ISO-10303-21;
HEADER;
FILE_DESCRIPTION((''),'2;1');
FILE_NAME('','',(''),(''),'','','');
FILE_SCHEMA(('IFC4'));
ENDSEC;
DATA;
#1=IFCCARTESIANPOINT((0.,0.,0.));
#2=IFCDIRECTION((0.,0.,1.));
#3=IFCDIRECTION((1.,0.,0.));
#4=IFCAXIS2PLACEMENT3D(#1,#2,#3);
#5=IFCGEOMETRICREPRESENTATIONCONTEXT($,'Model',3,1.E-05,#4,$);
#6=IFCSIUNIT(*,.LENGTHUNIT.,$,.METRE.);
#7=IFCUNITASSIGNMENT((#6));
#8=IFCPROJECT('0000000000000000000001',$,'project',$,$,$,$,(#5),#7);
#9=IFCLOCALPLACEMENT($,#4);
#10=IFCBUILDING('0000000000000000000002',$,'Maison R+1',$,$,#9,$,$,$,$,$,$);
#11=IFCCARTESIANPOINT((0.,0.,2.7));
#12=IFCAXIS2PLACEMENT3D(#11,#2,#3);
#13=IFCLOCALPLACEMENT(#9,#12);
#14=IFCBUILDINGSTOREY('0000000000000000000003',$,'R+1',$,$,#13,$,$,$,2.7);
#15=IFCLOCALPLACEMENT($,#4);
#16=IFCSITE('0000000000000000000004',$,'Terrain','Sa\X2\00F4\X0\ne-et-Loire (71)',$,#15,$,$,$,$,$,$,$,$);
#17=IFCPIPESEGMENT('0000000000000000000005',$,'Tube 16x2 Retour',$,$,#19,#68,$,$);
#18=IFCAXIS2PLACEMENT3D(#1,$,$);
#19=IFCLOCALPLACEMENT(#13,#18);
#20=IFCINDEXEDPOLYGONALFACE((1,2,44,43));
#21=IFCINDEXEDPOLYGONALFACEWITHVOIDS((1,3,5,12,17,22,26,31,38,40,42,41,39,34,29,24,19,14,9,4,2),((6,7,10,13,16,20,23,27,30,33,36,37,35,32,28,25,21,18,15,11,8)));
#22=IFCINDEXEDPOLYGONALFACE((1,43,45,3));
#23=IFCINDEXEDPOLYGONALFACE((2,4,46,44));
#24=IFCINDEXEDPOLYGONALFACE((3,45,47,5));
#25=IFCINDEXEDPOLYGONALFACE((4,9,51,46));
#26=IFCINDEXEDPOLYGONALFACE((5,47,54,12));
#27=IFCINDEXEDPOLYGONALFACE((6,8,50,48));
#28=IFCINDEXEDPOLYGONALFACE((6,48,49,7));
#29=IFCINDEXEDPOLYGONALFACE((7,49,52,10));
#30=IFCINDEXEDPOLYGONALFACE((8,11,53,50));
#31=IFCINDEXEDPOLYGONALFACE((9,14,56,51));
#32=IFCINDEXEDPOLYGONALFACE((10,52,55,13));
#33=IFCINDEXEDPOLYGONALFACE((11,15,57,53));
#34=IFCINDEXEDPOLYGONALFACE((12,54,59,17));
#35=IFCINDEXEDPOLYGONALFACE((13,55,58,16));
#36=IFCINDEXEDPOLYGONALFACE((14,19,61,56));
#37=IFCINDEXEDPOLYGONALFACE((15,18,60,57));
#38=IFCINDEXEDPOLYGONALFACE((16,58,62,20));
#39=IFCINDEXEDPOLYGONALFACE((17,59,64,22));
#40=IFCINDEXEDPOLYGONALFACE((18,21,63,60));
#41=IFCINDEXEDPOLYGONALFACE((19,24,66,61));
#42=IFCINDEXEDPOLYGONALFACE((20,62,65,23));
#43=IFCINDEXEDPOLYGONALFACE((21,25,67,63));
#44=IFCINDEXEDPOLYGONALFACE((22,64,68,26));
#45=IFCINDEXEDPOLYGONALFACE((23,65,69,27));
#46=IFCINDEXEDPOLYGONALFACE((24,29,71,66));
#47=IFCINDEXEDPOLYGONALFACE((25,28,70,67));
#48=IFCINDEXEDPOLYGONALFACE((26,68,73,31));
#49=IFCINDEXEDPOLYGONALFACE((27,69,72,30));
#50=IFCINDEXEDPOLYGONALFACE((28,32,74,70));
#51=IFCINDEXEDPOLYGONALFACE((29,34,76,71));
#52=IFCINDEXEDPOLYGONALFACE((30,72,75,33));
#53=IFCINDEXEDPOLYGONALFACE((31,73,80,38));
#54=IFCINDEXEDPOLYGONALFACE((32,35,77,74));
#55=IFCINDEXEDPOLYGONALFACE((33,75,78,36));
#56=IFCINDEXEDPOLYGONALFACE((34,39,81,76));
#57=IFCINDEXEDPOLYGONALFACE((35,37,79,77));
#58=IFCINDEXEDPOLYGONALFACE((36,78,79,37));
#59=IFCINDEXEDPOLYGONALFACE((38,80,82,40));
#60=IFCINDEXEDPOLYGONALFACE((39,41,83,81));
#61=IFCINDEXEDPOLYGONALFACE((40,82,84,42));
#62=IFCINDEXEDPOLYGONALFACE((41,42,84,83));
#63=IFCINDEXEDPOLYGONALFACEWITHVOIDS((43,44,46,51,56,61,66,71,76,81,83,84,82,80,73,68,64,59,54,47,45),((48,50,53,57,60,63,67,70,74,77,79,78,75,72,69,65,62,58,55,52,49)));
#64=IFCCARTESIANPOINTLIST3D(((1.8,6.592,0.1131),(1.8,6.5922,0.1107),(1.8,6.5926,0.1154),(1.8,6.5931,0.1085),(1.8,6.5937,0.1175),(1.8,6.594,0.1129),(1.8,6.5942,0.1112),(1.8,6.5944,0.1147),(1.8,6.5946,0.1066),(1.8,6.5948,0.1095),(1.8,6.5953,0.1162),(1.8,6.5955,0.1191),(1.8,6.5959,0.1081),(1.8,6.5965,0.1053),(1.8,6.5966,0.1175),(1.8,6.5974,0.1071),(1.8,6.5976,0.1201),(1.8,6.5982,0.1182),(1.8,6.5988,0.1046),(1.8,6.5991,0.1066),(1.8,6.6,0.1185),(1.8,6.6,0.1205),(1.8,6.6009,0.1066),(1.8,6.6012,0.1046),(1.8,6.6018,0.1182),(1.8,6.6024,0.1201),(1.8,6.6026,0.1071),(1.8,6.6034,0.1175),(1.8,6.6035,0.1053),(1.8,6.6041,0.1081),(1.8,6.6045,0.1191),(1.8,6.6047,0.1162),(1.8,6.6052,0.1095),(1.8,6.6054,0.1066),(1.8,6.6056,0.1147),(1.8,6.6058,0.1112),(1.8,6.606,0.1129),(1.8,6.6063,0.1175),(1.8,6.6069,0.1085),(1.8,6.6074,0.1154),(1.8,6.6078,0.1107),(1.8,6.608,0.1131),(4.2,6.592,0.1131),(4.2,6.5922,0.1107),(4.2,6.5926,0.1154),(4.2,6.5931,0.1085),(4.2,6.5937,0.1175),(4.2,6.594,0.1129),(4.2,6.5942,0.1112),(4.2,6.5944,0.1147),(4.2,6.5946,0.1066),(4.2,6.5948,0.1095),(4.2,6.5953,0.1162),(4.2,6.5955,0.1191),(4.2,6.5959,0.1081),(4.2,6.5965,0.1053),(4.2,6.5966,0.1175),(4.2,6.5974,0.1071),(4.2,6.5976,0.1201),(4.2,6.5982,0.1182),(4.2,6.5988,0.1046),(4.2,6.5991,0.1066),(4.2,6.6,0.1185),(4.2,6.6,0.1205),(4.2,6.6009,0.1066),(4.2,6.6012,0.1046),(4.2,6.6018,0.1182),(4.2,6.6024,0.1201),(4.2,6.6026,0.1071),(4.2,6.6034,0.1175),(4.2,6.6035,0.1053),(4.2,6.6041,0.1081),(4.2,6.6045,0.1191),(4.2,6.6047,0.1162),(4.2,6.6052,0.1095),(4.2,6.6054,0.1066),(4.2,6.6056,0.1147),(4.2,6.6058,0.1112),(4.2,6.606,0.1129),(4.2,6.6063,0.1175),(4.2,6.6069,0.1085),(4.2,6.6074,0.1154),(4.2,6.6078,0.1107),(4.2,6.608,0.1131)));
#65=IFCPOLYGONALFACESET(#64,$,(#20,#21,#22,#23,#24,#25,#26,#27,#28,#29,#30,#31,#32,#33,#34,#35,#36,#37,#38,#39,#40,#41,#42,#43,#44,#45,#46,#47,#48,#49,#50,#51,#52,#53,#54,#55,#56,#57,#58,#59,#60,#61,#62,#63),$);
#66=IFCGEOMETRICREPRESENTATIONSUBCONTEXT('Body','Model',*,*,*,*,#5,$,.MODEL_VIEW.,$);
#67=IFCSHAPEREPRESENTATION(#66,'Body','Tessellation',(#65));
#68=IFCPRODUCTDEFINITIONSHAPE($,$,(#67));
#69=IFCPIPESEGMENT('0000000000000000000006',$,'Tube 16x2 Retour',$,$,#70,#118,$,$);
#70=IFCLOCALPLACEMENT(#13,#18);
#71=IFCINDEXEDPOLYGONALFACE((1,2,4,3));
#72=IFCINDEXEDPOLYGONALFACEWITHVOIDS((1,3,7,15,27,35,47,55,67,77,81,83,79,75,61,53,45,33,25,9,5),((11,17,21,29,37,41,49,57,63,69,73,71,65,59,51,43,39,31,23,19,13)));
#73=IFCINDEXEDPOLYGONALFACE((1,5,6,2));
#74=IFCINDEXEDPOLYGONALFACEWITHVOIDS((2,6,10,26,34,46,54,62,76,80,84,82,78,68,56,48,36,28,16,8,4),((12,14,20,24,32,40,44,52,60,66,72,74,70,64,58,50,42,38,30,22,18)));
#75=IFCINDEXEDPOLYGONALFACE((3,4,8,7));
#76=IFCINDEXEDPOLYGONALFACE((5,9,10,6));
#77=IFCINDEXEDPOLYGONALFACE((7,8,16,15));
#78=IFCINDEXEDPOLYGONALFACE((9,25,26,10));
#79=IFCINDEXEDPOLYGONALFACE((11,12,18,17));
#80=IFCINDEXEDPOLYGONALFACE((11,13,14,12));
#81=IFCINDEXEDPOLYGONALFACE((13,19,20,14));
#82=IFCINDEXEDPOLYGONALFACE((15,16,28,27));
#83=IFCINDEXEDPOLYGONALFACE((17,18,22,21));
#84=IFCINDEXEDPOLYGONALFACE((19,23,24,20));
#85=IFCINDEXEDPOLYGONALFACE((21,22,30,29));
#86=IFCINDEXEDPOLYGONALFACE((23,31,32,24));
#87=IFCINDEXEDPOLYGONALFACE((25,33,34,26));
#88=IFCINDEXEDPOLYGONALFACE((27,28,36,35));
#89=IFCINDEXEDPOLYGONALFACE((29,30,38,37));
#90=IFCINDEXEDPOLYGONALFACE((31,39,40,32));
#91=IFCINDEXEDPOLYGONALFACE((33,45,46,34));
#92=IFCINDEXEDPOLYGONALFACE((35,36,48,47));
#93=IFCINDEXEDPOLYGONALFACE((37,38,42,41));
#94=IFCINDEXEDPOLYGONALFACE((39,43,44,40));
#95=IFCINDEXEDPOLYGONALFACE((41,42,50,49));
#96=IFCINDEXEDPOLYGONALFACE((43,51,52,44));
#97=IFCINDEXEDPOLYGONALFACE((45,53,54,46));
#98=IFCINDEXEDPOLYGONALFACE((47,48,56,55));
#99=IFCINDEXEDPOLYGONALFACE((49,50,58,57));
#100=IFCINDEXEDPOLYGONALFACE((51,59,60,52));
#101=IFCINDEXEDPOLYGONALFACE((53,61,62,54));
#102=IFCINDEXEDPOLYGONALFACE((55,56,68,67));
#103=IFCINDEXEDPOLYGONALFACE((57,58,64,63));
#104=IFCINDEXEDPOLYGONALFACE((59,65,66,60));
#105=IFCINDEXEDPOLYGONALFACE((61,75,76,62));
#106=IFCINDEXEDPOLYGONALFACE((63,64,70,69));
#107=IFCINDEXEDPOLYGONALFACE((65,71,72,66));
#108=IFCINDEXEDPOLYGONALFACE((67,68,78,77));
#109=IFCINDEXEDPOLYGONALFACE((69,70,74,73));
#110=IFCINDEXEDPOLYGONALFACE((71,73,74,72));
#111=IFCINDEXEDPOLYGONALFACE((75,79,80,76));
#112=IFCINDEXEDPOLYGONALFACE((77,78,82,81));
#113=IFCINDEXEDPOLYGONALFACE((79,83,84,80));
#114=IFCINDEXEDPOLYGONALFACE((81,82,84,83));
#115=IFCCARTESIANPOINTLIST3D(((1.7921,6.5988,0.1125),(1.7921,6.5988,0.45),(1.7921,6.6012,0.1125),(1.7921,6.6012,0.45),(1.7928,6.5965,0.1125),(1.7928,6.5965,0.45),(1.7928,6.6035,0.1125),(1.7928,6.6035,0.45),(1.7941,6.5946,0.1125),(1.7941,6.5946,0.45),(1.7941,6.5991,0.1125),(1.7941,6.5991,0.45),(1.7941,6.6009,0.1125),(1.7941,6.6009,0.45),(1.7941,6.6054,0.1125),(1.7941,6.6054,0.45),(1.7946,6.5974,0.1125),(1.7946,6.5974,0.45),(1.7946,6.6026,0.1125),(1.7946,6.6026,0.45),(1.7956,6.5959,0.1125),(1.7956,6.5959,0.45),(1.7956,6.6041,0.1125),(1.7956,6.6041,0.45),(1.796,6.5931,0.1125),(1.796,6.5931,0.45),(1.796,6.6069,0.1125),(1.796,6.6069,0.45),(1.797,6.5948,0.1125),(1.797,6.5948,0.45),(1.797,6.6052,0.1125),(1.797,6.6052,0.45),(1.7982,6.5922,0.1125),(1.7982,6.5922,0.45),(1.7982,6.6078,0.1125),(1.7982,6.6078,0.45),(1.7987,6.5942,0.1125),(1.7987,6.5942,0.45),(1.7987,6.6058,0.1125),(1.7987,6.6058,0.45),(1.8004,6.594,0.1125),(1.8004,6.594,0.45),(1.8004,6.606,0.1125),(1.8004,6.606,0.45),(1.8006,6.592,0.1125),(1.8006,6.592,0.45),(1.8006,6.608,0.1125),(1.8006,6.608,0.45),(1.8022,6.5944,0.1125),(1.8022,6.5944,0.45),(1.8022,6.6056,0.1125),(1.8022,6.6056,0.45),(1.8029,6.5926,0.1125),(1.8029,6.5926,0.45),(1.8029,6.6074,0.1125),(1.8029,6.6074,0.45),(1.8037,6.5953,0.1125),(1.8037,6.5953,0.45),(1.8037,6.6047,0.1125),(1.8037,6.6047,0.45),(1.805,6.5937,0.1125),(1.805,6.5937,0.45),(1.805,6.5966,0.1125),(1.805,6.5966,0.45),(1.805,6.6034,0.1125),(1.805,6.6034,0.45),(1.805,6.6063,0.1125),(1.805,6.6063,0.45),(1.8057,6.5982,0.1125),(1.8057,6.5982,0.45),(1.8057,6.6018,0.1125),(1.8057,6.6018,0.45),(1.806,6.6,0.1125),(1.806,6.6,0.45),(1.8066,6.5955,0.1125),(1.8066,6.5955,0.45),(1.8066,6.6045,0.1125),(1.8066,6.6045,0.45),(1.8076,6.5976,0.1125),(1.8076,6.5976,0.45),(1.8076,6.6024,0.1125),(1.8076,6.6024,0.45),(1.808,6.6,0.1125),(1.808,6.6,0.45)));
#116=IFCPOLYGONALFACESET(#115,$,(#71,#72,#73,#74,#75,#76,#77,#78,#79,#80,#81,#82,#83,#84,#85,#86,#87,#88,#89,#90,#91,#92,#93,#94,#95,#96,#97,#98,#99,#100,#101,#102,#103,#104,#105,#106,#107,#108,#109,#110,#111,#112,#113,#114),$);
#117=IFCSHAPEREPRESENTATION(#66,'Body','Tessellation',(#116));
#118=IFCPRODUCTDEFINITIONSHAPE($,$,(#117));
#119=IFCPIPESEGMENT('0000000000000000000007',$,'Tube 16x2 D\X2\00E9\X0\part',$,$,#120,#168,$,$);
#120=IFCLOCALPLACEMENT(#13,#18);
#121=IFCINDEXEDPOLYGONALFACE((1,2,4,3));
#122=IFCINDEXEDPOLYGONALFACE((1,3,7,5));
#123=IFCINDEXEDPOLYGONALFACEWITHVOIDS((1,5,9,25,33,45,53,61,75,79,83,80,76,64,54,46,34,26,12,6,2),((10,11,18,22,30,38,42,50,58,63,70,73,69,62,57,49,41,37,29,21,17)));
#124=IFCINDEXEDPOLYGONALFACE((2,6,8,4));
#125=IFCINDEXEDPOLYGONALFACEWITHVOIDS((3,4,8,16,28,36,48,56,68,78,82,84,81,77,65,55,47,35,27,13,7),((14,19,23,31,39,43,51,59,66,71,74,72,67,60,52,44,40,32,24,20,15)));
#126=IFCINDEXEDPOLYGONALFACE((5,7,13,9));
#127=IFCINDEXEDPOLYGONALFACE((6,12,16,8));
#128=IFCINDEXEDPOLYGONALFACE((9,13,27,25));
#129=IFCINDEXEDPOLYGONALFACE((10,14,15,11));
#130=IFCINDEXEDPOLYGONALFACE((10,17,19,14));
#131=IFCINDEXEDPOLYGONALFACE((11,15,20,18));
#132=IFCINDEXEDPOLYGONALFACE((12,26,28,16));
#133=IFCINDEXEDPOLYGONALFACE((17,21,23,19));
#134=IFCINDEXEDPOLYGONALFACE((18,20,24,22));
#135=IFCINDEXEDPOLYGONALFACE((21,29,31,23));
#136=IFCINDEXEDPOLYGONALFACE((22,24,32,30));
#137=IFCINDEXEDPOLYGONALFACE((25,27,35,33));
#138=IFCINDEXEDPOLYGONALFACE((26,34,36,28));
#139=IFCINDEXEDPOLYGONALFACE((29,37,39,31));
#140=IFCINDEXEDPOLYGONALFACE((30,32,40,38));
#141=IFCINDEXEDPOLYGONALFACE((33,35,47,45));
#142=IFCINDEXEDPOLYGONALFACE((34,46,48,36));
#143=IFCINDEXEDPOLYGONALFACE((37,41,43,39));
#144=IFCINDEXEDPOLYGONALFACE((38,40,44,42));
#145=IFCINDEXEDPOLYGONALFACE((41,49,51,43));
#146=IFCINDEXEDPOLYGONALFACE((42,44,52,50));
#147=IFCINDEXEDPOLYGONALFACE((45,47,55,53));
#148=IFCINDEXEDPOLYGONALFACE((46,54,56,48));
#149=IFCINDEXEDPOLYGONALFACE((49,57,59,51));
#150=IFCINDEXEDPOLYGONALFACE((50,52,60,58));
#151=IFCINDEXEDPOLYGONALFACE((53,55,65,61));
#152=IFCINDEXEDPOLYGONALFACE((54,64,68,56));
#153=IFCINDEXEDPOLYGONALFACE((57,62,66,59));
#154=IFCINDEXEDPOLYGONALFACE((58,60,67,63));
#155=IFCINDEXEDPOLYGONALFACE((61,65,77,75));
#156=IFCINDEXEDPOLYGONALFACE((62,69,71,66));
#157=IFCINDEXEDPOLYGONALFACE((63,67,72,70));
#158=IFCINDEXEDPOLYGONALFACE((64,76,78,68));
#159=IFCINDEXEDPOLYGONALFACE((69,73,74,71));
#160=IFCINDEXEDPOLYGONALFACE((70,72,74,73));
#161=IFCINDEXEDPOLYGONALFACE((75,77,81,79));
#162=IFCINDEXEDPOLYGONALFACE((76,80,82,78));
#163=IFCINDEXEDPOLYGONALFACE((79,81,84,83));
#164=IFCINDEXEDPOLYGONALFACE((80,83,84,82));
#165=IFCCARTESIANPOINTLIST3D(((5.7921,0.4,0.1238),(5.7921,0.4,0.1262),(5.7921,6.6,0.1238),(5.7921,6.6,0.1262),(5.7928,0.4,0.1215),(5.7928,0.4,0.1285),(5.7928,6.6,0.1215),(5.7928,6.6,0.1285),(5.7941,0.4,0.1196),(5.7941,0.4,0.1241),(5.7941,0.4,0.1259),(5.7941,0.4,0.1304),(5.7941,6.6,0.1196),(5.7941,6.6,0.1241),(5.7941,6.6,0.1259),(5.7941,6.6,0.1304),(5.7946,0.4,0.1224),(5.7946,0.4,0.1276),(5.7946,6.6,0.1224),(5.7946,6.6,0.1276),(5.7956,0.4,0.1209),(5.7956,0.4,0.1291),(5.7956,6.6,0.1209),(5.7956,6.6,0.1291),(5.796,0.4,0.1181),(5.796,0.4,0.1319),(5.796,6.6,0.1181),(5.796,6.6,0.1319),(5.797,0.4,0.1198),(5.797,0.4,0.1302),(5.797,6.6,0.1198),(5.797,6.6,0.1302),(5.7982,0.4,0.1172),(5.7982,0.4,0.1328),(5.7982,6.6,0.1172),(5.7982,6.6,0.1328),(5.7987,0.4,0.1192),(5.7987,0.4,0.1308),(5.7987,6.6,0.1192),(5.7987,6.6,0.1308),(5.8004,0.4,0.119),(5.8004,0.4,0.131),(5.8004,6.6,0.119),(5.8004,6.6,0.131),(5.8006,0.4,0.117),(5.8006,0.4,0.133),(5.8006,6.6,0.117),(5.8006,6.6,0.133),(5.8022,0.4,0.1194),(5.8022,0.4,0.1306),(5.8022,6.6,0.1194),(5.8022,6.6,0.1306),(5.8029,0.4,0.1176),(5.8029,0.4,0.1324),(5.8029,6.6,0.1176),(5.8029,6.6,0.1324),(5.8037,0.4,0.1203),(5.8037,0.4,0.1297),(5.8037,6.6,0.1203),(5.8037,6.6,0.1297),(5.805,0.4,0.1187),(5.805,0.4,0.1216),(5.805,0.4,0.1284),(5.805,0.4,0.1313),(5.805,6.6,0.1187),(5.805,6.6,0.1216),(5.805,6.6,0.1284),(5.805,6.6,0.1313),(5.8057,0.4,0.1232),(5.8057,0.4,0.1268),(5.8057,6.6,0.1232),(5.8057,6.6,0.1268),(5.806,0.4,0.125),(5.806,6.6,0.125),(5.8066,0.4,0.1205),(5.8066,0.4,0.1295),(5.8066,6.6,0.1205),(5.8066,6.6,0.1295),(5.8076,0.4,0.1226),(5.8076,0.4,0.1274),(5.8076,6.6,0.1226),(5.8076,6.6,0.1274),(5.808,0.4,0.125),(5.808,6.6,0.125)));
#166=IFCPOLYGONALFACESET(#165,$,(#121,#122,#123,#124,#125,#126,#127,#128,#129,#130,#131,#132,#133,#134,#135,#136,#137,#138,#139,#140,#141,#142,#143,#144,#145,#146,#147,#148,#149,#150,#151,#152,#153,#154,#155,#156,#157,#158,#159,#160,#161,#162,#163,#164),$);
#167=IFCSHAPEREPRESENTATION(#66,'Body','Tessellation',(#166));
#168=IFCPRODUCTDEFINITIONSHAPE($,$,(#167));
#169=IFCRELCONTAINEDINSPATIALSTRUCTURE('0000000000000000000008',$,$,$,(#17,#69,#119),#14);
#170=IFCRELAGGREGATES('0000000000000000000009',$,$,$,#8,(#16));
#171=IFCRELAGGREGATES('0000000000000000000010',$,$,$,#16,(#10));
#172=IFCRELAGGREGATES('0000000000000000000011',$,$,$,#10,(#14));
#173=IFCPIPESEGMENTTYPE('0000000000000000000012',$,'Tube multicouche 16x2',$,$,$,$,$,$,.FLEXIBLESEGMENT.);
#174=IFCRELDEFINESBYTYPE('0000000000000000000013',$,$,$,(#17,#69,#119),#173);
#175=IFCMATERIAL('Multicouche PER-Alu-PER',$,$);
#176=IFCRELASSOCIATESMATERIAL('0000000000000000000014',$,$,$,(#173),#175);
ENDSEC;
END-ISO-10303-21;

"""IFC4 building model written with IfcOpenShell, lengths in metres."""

from ifc_helpers import new_model, si_unit, frame, origin_with_axes, place, context, subcontext, project, spatial, hollow_circle, extrude, material, type_object, element, save


model = new_model("IFC4")

# Units and contexts
model_context = context("Model", 3, precision=1e-05, world=origin_with_axes())
body_context = subcontext(model_context, "Body", "Model", "MODEL_VIEW")
ifc_project = project(units=[si_unit("LENGTHUNIT", "METRE")], contexts=[model_context])

# Site, building, storey
site_placement = place(None, origin_with_axes())
site = spatial("IfcSite", under=ifc_project, at=site_placement, Name="Terrain", Description="Saône-et-Loire (71)")
building_placement = place(None, origin_with_axes())
building = spatial("IfcBuilding", under=site, at=building_placement, Name="Maison R+1")
storey_placement = place(building_placement, frame((0.0, 0.0, 2.7), z_axis=(0.0, 0.0, 1.0), x_axis=(1.0, 0.0, 0.0)))
storey = spatial("IfcBuildingStorey", under=building, at=storey_placement, Name="R+1", Elevation=2.7)

# Pipe segments
ifc_material_1 = material(Name="Multicouche PER-Alu-PER")
pipe_segment_type = type_object("IfcPipeSegmentType", Name="Tube multicouche 16x2", PredefinedType="FLEXIBLESEGMENT", material=ifc_material_1)
pipe_segment_1_placement = place(storey_placement, frame((4.2, 6.6, 0.1125), z_axis=(-1.0, 0.0, 0.0), x_axis=(0.0, 0.0, 1.0)))
element("IfcPipeSegment", 1, at=pipe_segment_1_placement, inside=storey, type_object=pipe_segment_type, Name="Tube 16x2 Retour", context=body_context, shape_type="SweptSolid", body=[
    extrude(hollow_circle(Radius=0.008, WallThickness=0.002), origin_with_axes(), (0.0, 0.0, 1.0), 2.4),
])
pipe_segment_2_placement = place(storey_placement, frame((1.8, 6.6, 0.1125), z_axis=(0.0, 0.0, 1.0), x_axis=(1.0, 0.0, 0.0)))
element("IfcPipeSegment", 2, at=pipe_segment_2_placement, inside=storey, type_object=pipe_segment_type, Name="Tube 16x2 Retour", context=body_context, shape_type="SweptSolid", body=[
    extrude(hollow_circle(Radius=0.008, WallThickness=0.002), origin_with_axes(), (0.0, 0.0, 1.0), 0.3375),
])
pipe_segment_3_placement = place(storey_placement, frame((5.8, 0.4, 0.125), z_axis=(0.0, 1.0, 0.0), x_axis=(1.0, 0.0, 0.0)))
element("IfcPipeSegment", 3, at=pipe_segment_3_placement, inside=storey, type_object=pipe_segment_type, Name="Tube 16x2 Départ", context=body_context, shape_type="SweptSolid", body=[
    extrude(hollow_circle(Radius=0.008, WallThickness=0.002), origin_with_axes(), (0.0, 0.0, 1.0), 6.2),
])

save(model, "model.ifc")
